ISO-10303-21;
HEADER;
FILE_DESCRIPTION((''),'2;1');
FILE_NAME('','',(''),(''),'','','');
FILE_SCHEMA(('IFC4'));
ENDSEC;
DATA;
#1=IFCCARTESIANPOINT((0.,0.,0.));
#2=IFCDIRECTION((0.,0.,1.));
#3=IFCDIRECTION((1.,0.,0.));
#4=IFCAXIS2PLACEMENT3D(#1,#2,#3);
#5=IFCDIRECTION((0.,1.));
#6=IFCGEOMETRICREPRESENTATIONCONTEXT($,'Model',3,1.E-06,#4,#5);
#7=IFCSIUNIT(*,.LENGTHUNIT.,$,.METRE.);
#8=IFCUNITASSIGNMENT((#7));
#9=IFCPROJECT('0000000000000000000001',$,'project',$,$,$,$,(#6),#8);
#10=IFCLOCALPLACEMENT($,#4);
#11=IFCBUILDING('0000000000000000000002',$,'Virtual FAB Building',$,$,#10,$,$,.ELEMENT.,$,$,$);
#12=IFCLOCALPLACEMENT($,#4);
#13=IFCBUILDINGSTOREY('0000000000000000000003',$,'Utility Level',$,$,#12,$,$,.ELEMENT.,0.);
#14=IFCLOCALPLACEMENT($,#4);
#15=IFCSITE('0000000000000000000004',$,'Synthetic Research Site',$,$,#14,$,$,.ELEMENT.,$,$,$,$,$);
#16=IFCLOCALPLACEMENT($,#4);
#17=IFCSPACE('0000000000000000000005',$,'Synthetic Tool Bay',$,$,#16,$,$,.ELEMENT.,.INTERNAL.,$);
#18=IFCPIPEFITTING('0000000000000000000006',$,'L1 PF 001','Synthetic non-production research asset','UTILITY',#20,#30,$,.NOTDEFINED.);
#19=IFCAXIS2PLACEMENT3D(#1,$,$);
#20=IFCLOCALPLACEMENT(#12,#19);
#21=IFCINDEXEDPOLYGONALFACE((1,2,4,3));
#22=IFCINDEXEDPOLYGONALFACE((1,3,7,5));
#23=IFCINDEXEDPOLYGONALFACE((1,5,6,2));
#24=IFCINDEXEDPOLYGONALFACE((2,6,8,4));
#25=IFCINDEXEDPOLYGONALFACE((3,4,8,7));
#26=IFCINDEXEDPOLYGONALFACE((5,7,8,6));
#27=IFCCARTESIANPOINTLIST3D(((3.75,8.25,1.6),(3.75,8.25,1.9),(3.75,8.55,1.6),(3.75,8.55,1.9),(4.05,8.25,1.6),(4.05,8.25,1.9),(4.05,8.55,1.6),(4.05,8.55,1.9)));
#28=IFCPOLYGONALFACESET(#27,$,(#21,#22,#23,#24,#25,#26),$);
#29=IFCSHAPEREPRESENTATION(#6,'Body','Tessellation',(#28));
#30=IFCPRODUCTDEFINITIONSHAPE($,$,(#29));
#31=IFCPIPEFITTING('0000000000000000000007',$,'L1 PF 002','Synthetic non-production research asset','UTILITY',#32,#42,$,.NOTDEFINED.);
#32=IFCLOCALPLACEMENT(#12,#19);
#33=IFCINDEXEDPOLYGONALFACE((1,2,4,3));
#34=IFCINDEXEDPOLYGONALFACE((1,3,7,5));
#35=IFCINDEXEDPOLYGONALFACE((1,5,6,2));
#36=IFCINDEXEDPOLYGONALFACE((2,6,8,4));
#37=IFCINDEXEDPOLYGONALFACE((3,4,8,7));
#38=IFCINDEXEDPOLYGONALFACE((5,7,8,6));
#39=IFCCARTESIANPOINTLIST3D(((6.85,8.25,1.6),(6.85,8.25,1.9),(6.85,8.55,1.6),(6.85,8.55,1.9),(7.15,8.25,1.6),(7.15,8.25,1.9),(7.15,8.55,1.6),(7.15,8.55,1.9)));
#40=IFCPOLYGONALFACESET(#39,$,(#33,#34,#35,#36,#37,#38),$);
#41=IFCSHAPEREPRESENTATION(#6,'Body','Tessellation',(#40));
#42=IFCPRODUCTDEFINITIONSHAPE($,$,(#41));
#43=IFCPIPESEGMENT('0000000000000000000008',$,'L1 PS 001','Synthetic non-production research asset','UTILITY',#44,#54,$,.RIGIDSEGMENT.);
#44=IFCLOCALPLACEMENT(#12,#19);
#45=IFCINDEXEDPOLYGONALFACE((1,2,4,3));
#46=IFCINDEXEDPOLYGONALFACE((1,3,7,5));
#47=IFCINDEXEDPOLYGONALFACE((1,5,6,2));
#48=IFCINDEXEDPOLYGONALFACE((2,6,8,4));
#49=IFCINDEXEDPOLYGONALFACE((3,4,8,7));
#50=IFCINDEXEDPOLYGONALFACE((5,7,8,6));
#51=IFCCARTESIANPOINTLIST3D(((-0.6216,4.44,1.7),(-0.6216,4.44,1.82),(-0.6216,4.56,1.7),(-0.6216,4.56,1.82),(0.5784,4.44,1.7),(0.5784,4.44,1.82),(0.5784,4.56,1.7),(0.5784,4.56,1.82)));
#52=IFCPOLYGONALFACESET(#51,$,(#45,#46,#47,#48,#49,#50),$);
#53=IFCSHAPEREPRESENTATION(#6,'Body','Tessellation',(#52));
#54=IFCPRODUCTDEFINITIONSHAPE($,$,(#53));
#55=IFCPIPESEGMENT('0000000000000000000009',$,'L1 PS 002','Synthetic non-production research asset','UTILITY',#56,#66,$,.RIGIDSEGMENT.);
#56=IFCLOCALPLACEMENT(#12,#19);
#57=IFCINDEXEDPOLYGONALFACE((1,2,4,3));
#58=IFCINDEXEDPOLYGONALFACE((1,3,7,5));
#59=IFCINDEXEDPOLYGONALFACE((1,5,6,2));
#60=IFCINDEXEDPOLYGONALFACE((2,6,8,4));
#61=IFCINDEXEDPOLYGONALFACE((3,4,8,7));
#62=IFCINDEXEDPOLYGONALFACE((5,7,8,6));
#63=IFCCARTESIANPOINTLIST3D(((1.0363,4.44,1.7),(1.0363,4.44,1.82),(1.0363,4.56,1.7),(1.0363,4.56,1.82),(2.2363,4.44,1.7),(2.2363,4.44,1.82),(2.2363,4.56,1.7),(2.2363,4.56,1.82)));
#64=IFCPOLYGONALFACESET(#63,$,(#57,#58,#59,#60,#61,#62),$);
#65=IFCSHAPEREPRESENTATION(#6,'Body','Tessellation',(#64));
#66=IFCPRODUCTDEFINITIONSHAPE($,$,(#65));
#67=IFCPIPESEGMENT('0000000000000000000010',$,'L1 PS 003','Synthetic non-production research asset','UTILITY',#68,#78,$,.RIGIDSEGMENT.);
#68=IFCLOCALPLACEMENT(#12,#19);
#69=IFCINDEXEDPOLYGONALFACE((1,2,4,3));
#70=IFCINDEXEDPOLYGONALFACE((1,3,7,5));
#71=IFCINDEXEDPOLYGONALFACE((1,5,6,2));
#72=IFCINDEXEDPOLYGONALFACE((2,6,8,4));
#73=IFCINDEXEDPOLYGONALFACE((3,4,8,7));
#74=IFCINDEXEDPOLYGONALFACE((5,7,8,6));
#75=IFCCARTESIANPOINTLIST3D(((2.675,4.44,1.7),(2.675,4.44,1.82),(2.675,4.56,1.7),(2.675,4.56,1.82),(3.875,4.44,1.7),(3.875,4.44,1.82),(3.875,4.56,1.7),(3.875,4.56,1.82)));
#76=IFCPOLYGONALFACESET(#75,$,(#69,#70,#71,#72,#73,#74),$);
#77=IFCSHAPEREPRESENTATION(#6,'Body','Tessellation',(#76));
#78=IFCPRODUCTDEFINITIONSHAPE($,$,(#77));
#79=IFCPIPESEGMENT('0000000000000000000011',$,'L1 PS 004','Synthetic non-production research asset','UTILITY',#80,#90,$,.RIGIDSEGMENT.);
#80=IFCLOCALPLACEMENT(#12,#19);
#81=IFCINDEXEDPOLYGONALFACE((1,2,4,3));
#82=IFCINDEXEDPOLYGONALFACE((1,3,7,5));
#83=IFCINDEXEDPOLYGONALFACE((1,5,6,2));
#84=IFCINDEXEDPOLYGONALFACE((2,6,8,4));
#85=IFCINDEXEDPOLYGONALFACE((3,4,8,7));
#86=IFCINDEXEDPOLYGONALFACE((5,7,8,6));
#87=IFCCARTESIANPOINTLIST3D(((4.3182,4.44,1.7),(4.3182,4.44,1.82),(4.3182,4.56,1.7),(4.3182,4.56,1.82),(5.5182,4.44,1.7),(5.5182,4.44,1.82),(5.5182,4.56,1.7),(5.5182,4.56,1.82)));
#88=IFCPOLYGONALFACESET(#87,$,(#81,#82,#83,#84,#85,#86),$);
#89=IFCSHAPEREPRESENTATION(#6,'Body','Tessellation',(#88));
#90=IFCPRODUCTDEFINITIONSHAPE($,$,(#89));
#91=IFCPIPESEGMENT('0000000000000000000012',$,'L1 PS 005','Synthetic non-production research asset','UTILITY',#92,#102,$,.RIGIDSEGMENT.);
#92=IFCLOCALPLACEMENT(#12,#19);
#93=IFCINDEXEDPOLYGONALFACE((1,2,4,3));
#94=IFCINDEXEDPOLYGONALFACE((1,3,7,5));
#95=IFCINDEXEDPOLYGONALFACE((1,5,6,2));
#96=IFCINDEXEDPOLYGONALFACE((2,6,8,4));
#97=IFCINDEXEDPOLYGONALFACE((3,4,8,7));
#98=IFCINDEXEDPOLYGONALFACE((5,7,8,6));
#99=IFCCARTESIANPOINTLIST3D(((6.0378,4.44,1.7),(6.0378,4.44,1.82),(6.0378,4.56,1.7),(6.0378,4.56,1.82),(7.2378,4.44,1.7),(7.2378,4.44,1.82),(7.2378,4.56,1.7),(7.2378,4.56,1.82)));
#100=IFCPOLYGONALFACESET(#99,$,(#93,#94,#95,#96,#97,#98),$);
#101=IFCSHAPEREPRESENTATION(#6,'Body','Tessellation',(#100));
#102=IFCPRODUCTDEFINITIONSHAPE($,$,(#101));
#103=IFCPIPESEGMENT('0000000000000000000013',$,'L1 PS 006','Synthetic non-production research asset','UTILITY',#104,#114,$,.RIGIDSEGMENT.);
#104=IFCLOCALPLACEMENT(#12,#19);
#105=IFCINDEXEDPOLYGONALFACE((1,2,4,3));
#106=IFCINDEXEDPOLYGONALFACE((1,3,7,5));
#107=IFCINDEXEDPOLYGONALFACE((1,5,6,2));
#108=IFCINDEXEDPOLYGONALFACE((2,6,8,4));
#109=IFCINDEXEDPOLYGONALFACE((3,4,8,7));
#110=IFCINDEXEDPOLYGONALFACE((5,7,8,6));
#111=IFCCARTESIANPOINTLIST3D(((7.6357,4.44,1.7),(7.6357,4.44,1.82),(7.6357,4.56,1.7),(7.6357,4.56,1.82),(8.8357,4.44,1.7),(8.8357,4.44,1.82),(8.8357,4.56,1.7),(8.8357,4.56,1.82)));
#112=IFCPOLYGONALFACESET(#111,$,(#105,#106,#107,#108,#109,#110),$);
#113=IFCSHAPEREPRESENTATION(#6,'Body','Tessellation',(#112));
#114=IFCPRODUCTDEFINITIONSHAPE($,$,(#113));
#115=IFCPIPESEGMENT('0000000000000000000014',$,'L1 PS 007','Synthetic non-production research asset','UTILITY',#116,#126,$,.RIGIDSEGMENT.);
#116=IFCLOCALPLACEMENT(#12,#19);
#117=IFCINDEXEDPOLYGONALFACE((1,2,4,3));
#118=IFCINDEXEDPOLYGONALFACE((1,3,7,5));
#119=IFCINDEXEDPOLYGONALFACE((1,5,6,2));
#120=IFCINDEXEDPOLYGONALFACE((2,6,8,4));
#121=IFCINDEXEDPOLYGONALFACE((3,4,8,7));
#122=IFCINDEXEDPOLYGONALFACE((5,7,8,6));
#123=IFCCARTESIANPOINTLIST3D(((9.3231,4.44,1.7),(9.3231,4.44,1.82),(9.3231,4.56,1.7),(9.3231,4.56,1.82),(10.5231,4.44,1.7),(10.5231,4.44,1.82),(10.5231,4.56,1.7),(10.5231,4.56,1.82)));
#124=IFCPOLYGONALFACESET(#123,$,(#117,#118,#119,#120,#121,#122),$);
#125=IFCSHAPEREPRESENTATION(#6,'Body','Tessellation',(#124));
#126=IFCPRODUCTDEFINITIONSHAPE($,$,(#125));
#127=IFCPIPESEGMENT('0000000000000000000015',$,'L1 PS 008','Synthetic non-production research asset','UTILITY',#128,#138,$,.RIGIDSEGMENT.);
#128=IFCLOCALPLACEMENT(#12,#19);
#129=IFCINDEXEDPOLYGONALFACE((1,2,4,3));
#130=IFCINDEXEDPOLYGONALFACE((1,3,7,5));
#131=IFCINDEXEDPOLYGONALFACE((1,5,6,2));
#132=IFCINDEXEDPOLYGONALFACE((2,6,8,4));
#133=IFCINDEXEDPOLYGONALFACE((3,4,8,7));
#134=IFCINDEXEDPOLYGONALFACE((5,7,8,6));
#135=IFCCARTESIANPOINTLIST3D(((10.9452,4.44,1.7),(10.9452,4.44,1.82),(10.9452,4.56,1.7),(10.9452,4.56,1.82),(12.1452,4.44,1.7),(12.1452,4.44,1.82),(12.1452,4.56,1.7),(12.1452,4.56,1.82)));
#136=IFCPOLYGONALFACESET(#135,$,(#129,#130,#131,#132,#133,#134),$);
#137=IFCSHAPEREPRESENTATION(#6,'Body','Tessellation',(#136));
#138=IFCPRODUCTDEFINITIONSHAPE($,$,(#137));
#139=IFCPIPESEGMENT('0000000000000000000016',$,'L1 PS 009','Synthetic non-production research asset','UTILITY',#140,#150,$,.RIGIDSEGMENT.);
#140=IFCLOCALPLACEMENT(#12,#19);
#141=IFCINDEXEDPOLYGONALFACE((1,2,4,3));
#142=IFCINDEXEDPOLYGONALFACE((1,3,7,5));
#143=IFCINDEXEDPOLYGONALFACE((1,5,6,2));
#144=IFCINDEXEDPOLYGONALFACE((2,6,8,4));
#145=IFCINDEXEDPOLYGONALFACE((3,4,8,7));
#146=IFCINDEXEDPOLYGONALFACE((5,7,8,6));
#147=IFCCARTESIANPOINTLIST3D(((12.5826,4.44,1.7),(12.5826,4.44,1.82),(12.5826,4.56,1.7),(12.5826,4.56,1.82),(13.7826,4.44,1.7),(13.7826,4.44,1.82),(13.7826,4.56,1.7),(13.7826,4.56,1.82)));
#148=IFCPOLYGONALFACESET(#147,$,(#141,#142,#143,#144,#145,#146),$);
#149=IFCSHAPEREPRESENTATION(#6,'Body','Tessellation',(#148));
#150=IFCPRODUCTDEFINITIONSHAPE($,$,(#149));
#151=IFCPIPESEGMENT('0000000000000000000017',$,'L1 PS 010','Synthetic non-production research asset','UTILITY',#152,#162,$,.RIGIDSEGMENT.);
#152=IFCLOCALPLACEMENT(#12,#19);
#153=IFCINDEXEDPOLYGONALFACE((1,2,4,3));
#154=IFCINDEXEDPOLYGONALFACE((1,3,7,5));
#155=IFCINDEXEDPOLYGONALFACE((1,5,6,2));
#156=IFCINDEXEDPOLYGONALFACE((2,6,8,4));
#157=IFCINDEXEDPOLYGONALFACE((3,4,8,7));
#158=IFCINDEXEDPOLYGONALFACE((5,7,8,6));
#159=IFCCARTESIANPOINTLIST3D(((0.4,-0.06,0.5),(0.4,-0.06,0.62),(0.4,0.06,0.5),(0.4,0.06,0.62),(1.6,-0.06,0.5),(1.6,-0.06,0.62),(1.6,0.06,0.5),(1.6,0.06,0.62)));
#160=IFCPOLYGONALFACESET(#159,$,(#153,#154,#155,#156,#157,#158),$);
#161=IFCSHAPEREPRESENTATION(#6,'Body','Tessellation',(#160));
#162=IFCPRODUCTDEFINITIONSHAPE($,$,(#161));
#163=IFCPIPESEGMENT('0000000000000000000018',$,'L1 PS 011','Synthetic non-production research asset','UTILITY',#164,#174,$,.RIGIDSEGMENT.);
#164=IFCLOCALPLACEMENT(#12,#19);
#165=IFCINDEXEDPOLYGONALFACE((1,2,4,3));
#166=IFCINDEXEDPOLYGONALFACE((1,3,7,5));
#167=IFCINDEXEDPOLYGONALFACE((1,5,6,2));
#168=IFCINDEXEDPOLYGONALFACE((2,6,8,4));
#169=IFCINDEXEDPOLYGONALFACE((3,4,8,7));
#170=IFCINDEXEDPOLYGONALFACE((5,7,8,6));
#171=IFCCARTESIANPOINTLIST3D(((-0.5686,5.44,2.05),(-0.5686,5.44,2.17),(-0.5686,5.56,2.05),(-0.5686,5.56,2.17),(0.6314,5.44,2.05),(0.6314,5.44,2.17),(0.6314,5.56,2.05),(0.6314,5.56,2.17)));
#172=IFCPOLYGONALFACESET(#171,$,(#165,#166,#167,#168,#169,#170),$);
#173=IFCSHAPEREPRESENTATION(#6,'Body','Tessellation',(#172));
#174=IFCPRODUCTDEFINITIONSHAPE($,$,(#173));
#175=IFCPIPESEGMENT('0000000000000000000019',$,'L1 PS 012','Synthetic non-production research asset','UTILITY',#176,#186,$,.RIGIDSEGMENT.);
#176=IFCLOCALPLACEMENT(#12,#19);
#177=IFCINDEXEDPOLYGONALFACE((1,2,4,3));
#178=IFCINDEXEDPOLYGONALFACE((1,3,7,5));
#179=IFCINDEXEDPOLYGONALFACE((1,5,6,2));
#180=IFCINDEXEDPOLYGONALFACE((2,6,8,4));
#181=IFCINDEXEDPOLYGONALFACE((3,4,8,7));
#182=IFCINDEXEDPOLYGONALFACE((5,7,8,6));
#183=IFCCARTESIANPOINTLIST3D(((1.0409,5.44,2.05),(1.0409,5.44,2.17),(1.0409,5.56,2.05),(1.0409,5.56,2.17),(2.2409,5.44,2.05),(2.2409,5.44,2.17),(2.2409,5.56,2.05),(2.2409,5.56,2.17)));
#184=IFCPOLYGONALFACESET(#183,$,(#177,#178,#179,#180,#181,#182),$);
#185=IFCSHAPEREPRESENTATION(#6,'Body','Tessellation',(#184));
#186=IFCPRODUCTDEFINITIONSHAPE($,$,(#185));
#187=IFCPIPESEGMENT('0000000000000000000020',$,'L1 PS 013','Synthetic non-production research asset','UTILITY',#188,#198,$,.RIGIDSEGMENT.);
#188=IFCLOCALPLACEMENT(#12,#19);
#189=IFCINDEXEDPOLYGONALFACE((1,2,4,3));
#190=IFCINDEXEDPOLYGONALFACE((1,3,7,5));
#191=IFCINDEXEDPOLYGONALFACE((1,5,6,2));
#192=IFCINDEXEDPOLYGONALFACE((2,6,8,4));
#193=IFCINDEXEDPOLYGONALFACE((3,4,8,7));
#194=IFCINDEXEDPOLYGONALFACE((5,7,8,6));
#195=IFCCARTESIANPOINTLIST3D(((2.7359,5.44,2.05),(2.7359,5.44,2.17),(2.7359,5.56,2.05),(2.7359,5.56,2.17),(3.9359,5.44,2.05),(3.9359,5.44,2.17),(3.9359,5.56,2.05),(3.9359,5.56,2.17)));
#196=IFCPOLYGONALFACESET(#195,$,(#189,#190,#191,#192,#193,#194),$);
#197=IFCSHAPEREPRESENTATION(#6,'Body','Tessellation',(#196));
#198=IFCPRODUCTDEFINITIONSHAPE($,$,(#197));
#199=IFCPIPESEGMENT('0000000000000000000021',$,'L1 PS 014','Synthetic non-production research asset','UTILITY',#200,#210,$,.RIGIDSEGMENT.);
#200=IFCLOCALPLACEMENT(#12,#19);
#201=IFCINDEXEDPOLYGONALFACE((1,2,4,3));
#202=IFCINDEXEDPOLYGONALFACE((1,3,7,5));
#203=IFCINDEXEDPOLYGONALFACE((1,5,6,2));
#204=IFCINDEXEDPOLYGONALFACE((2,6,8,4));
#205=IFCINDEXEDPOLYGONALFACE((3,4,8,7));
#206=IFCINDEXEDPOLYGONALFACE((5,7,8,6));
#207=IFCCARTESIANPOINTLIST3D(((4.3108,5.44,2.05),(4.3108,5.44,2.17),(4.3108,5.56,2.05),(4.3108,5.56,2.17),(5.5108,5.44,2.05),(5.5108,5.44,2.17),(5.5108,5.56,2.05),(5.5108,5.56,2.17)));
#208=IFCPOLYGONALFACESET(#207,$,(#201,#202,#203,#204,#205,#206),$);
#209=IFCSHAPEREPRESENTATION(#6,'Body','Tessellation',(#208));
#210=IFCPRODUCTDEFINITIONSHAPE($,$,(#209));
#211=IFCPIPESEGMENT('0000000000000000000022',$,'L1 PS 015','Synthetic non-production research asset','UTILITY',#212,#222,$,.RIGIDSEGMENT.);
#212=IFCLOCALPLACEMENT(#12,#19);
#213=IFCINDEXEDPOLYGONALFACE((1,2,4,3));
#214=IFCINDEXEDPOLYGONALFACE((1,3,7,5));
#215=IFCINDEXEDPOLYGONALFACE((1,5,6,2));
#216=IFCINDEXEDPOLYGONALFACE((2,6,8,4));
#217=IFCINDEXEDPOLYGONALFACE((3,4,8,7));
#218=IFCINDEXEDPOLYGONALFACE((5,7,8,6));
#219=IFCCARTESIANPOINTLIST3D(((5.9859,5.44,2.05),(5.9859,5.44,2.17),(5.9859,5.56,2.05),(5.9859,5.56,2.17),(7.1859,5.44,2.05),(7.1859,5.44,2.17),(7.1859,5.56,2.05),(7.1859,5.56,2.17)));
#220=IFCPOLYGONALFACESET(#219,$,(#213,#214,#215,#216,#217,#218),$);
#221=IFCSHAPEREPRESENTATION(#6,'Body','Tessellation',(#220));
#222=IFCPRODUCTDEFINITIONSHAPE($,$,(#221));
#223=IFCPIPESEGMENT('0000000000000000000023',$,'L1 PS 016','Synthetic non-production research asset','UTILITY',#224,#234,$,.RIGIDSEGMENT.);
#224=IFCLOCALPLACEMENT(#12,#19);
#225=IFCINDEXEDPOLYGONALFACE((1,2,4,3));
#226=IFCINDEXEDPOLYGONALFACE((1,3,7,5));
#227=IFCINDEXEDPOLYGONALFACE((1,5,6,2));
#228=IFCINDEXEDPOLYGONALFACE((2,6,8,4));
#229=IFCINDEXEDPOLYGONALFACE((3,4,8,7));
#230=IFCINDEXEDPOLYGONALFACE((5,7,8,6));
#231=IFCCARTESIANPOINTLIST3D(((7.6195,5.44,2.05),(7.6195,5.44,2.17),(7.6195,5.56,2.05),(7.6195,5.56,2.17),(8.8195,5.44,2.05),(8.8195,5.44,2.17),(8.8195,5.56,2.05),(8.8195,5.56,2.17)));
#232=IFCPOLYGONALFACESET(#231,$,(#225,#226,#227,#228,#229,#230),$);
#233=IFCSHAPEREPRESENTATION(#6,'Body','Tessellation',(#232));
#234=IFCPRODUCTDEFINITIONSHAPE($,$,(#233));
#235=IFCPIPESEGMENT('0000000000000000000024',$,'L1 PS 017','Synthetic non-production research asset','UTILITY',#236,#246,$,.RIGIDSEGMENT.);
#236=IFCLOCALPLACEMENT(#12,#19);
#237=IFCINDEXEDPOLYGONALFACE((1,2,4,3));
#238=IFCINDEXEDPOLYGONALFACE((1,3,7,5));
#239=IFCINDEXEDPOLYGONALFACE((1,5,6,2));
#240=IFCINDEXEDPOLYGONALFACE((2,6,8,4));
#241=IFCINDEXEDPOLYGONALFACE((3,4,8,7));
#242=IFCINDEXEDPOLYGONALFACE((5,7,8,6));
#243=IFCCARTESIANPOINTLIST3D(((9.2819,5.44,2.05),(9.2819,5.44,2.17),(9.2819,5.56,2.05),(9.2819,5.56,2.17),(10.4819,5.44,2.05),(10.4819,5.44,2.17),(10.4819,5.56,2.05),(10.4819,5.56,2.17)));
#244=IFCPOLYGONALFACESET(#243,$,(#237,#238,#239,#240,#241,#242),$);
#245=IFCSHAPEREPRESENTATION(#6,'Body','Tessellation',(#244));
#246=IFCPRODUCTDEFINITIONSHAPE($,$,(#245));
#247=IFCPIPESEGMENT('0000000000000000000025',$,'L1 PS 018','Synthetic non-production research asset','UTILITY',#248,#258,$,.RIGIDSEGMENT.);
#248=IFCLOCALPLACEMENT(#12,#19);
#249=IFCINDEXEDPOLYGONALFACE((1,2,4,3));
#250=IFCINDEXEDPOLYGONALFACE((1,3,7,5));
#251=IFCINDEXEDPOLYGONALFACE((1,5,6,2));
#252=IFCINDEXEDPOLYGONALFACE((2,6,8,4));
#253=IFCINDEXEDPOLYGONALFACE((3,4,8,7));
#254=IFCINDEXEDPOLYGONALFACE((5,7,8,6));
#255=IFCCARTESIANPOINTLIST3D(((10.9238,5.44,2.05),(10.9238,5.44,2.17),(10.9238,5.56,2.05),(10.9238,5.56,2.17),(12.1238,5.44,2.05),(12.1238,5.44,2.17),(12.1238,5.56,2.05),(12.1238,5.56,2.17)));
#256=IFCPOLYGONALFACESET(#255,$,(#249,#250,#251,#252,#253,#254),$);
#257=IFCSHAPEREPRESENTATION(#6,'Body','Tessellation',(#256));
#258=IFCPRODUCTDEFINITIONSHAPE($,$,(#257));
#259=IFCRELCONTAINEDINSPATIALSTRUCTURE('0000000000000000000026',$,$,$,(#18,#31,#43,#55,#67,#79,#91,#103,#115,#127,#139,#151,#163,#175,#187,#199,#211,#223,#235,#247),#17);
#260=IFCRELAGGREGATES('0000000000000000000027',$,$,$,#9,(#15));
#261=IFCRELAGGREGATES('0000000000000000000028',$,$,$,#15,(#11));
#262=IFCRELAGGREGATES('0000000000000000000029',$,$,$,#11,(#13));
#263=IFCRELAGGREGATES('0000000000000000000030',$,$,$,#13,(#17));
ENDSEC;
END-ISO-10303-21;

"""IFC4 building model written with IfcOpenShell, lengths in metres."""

from ifc_helpers import new_model, si_unit, direction, frame, origin_with_axes, origin_2d_with_axis, place, context, project, spatial, rectangle, extrude, element, save


model = new_model("IFC4")

# Units and contexts
model_context = context("Model", 3, precision=1e-06, world=origin_with_axes(), true_north=direction((0.0, 1.0)))
ifc_project = project(units=[si_unit("LENGTHUNIT", "METRE")], contexts=[model_context])

# Site, building, storey, space
site_placement = place(None, origin_with_axes())
site = spatial("IfcSite", under=ifc_project, at=site_placement, Name="Synthetic Research Site", CompositionType="ELEMENT")
building_placement = place(None, origin_with_axes())
building = spatial("IfcBuilding", under=site, at=building_placement, Name="Virtual FAB Building", CompositionType="ELEMENT")
storey_placement = place(None, origin_with_axes())
storey = spatial("IfcBuildingStorey", under=building, at=storey_placement, Name="Utility Level", CompositionType="ELEMENT", Elevation=0.0)
space_placement = place(None, origin_with_axes())
space = spatial("IfcSpace", under=storey, at=space_placement, Name="Synthetic Tool Bay", CompositionType="ELEMENT", PredefinedType="INTERNAL")

# Pipe fittings
for number, where, z_axis, x_axis, name in (
    (1, (3.9, 8.4, 1.6), (0.0, 0.0, 1.0), (1.0, 0.0, 0.0), "L1 PF 001"),
    (2, (7.0, 8.4, 1.6), (0.0, 0.0, 1.0), (1.0, 0.0, 0.0), "L1 PF 002"),
):
    element("IfcPipeFitting", number, at=place(None, frame(where, z_axis=z_axis, x_axis=x_axis)), inside=space, Name=name, Description="Synthetic non-production research asset", ObjectType="UTILITY", PredefinedType="NOTDEFINED", context=model_context, shape_type="SweptSolid", body=[
        extrude(rectangle(XDim=0.3, YDim=0.3, at=origin_2d_with_axis()), origin_with_axes(), (0.0, 0.0, 1.0), 0.3),
    ])

# Pipe segments
for number, where, z_axis, x_axis, name in (
    (3, (-0.0216, 4.5, 1.7), (0.0, 0.0, 1.0), (1.0, 0.0, 0.0), "L1 PS 001"),
    (4, (1.6363, 4.5, 1.7), (0.0, 0.0, 1.0), (1.0, 0.0, 0.0), "L1 PS 002"),
    (5, (3.275, 4.5, 1.7), (0.0, 0.0, 1.0), (1.0, 0.0, 0.0), "L1 PS 003"),
    (6, (4.9182, 4.5, 1.7), (0.0, 0.0, 1.0), (1.0, 0.0, 0.0), "L1 PS 004"),
    (7, (6.6378, 4.5, 1.7), (0.0, 0.0, 1.0), (1.0, 0.0, 0.0), "L1 PS 005"),
    (8, (8.2357, 4.5, 1.7), (0.0, 0.0, 1.0), (1.0, 0.0, 0.0), "L1 PS 006"),
    (9, (9.9231, 4.5, 1.7), (0.0, 0.0, 1.0), (1.0, 0.0, 0.0), "L1 PS 007"),
    (10, (11.5452, 4.5, 1.7), (0.0, 0.0, 1.0), (1.0, 0.0, 0.0), "L1 PS 008"),
    (11, (13.1826, 4.5, 1.7), (0.0, 0.0, 1.0), (1.0, 0.0, 0.0), "L1 PS 009"),
    (12, (1.0, 0.0, 0.5), (0.0, 0.0, 1.0), (1.0, 0.0, 0.0), "L1 PS 010"),
    (13, (0.0314, 5.5, 2.05), (0.0, 0.0, 1.0), (1.0, 0.0, 0.0), "L1 PS 011"),
    (14, (1.6409, 5.5, 2.05), (0.0, 0.0, 1.0), (1.0, 0.0, 0.0), "L1 PS 012"),
    (15, (3.3359, 5.5, 2.05), (0.0, 0.0, 1.0), (1.0, 0.0, 0.0), "L1 PS 013"),
    (16, (4.9108, 5.5, 2.05), (0.0, 0.0, 1.0), (1.0, 0.0, 0.0), "L1 PS 014"),
    (17, (6.5859, 5.5, 2.05), (0.0, 0.0, 1.0), (1.0, 0.0, 0.0), "L1 PS 015"),
    (18, (8.2195, 5.5, 2.05), (0.0, 0.0, 1.0), (1.0, 0.0, 0.0), "L1 PS 016"),
    (19, (9.8819, 5.5, 2.05), (0.0, 0.0, 1.0), (1.0, 0.0, 0.0), "L1 PS 017"),
    (20, (11.5238, 5.5, 2.05), (0.0, 0.0, 1.0), (1.0, 0.0, 0.0), "L1 PS 018"),
):
    element("IfcPipeSegment", number, at=place(None, frame(where, z_axis=z_axis, x_axis=x_axis)), inside=space, Name=name, Description="Synthetic non-production research asset", ObjectType="UTILITY", PredefinedType="RIGIDSEGMENT", context=model_context, shape_type="SweptSolid", body=[
        extrude(rectangle(XDim=1.2, YDim=0.12, at=origin_2d_with_axis()), origin_with_axes(), (0.0, 0.0, 1.0), 0.12),
    ])

save(model, "model.ifc")
